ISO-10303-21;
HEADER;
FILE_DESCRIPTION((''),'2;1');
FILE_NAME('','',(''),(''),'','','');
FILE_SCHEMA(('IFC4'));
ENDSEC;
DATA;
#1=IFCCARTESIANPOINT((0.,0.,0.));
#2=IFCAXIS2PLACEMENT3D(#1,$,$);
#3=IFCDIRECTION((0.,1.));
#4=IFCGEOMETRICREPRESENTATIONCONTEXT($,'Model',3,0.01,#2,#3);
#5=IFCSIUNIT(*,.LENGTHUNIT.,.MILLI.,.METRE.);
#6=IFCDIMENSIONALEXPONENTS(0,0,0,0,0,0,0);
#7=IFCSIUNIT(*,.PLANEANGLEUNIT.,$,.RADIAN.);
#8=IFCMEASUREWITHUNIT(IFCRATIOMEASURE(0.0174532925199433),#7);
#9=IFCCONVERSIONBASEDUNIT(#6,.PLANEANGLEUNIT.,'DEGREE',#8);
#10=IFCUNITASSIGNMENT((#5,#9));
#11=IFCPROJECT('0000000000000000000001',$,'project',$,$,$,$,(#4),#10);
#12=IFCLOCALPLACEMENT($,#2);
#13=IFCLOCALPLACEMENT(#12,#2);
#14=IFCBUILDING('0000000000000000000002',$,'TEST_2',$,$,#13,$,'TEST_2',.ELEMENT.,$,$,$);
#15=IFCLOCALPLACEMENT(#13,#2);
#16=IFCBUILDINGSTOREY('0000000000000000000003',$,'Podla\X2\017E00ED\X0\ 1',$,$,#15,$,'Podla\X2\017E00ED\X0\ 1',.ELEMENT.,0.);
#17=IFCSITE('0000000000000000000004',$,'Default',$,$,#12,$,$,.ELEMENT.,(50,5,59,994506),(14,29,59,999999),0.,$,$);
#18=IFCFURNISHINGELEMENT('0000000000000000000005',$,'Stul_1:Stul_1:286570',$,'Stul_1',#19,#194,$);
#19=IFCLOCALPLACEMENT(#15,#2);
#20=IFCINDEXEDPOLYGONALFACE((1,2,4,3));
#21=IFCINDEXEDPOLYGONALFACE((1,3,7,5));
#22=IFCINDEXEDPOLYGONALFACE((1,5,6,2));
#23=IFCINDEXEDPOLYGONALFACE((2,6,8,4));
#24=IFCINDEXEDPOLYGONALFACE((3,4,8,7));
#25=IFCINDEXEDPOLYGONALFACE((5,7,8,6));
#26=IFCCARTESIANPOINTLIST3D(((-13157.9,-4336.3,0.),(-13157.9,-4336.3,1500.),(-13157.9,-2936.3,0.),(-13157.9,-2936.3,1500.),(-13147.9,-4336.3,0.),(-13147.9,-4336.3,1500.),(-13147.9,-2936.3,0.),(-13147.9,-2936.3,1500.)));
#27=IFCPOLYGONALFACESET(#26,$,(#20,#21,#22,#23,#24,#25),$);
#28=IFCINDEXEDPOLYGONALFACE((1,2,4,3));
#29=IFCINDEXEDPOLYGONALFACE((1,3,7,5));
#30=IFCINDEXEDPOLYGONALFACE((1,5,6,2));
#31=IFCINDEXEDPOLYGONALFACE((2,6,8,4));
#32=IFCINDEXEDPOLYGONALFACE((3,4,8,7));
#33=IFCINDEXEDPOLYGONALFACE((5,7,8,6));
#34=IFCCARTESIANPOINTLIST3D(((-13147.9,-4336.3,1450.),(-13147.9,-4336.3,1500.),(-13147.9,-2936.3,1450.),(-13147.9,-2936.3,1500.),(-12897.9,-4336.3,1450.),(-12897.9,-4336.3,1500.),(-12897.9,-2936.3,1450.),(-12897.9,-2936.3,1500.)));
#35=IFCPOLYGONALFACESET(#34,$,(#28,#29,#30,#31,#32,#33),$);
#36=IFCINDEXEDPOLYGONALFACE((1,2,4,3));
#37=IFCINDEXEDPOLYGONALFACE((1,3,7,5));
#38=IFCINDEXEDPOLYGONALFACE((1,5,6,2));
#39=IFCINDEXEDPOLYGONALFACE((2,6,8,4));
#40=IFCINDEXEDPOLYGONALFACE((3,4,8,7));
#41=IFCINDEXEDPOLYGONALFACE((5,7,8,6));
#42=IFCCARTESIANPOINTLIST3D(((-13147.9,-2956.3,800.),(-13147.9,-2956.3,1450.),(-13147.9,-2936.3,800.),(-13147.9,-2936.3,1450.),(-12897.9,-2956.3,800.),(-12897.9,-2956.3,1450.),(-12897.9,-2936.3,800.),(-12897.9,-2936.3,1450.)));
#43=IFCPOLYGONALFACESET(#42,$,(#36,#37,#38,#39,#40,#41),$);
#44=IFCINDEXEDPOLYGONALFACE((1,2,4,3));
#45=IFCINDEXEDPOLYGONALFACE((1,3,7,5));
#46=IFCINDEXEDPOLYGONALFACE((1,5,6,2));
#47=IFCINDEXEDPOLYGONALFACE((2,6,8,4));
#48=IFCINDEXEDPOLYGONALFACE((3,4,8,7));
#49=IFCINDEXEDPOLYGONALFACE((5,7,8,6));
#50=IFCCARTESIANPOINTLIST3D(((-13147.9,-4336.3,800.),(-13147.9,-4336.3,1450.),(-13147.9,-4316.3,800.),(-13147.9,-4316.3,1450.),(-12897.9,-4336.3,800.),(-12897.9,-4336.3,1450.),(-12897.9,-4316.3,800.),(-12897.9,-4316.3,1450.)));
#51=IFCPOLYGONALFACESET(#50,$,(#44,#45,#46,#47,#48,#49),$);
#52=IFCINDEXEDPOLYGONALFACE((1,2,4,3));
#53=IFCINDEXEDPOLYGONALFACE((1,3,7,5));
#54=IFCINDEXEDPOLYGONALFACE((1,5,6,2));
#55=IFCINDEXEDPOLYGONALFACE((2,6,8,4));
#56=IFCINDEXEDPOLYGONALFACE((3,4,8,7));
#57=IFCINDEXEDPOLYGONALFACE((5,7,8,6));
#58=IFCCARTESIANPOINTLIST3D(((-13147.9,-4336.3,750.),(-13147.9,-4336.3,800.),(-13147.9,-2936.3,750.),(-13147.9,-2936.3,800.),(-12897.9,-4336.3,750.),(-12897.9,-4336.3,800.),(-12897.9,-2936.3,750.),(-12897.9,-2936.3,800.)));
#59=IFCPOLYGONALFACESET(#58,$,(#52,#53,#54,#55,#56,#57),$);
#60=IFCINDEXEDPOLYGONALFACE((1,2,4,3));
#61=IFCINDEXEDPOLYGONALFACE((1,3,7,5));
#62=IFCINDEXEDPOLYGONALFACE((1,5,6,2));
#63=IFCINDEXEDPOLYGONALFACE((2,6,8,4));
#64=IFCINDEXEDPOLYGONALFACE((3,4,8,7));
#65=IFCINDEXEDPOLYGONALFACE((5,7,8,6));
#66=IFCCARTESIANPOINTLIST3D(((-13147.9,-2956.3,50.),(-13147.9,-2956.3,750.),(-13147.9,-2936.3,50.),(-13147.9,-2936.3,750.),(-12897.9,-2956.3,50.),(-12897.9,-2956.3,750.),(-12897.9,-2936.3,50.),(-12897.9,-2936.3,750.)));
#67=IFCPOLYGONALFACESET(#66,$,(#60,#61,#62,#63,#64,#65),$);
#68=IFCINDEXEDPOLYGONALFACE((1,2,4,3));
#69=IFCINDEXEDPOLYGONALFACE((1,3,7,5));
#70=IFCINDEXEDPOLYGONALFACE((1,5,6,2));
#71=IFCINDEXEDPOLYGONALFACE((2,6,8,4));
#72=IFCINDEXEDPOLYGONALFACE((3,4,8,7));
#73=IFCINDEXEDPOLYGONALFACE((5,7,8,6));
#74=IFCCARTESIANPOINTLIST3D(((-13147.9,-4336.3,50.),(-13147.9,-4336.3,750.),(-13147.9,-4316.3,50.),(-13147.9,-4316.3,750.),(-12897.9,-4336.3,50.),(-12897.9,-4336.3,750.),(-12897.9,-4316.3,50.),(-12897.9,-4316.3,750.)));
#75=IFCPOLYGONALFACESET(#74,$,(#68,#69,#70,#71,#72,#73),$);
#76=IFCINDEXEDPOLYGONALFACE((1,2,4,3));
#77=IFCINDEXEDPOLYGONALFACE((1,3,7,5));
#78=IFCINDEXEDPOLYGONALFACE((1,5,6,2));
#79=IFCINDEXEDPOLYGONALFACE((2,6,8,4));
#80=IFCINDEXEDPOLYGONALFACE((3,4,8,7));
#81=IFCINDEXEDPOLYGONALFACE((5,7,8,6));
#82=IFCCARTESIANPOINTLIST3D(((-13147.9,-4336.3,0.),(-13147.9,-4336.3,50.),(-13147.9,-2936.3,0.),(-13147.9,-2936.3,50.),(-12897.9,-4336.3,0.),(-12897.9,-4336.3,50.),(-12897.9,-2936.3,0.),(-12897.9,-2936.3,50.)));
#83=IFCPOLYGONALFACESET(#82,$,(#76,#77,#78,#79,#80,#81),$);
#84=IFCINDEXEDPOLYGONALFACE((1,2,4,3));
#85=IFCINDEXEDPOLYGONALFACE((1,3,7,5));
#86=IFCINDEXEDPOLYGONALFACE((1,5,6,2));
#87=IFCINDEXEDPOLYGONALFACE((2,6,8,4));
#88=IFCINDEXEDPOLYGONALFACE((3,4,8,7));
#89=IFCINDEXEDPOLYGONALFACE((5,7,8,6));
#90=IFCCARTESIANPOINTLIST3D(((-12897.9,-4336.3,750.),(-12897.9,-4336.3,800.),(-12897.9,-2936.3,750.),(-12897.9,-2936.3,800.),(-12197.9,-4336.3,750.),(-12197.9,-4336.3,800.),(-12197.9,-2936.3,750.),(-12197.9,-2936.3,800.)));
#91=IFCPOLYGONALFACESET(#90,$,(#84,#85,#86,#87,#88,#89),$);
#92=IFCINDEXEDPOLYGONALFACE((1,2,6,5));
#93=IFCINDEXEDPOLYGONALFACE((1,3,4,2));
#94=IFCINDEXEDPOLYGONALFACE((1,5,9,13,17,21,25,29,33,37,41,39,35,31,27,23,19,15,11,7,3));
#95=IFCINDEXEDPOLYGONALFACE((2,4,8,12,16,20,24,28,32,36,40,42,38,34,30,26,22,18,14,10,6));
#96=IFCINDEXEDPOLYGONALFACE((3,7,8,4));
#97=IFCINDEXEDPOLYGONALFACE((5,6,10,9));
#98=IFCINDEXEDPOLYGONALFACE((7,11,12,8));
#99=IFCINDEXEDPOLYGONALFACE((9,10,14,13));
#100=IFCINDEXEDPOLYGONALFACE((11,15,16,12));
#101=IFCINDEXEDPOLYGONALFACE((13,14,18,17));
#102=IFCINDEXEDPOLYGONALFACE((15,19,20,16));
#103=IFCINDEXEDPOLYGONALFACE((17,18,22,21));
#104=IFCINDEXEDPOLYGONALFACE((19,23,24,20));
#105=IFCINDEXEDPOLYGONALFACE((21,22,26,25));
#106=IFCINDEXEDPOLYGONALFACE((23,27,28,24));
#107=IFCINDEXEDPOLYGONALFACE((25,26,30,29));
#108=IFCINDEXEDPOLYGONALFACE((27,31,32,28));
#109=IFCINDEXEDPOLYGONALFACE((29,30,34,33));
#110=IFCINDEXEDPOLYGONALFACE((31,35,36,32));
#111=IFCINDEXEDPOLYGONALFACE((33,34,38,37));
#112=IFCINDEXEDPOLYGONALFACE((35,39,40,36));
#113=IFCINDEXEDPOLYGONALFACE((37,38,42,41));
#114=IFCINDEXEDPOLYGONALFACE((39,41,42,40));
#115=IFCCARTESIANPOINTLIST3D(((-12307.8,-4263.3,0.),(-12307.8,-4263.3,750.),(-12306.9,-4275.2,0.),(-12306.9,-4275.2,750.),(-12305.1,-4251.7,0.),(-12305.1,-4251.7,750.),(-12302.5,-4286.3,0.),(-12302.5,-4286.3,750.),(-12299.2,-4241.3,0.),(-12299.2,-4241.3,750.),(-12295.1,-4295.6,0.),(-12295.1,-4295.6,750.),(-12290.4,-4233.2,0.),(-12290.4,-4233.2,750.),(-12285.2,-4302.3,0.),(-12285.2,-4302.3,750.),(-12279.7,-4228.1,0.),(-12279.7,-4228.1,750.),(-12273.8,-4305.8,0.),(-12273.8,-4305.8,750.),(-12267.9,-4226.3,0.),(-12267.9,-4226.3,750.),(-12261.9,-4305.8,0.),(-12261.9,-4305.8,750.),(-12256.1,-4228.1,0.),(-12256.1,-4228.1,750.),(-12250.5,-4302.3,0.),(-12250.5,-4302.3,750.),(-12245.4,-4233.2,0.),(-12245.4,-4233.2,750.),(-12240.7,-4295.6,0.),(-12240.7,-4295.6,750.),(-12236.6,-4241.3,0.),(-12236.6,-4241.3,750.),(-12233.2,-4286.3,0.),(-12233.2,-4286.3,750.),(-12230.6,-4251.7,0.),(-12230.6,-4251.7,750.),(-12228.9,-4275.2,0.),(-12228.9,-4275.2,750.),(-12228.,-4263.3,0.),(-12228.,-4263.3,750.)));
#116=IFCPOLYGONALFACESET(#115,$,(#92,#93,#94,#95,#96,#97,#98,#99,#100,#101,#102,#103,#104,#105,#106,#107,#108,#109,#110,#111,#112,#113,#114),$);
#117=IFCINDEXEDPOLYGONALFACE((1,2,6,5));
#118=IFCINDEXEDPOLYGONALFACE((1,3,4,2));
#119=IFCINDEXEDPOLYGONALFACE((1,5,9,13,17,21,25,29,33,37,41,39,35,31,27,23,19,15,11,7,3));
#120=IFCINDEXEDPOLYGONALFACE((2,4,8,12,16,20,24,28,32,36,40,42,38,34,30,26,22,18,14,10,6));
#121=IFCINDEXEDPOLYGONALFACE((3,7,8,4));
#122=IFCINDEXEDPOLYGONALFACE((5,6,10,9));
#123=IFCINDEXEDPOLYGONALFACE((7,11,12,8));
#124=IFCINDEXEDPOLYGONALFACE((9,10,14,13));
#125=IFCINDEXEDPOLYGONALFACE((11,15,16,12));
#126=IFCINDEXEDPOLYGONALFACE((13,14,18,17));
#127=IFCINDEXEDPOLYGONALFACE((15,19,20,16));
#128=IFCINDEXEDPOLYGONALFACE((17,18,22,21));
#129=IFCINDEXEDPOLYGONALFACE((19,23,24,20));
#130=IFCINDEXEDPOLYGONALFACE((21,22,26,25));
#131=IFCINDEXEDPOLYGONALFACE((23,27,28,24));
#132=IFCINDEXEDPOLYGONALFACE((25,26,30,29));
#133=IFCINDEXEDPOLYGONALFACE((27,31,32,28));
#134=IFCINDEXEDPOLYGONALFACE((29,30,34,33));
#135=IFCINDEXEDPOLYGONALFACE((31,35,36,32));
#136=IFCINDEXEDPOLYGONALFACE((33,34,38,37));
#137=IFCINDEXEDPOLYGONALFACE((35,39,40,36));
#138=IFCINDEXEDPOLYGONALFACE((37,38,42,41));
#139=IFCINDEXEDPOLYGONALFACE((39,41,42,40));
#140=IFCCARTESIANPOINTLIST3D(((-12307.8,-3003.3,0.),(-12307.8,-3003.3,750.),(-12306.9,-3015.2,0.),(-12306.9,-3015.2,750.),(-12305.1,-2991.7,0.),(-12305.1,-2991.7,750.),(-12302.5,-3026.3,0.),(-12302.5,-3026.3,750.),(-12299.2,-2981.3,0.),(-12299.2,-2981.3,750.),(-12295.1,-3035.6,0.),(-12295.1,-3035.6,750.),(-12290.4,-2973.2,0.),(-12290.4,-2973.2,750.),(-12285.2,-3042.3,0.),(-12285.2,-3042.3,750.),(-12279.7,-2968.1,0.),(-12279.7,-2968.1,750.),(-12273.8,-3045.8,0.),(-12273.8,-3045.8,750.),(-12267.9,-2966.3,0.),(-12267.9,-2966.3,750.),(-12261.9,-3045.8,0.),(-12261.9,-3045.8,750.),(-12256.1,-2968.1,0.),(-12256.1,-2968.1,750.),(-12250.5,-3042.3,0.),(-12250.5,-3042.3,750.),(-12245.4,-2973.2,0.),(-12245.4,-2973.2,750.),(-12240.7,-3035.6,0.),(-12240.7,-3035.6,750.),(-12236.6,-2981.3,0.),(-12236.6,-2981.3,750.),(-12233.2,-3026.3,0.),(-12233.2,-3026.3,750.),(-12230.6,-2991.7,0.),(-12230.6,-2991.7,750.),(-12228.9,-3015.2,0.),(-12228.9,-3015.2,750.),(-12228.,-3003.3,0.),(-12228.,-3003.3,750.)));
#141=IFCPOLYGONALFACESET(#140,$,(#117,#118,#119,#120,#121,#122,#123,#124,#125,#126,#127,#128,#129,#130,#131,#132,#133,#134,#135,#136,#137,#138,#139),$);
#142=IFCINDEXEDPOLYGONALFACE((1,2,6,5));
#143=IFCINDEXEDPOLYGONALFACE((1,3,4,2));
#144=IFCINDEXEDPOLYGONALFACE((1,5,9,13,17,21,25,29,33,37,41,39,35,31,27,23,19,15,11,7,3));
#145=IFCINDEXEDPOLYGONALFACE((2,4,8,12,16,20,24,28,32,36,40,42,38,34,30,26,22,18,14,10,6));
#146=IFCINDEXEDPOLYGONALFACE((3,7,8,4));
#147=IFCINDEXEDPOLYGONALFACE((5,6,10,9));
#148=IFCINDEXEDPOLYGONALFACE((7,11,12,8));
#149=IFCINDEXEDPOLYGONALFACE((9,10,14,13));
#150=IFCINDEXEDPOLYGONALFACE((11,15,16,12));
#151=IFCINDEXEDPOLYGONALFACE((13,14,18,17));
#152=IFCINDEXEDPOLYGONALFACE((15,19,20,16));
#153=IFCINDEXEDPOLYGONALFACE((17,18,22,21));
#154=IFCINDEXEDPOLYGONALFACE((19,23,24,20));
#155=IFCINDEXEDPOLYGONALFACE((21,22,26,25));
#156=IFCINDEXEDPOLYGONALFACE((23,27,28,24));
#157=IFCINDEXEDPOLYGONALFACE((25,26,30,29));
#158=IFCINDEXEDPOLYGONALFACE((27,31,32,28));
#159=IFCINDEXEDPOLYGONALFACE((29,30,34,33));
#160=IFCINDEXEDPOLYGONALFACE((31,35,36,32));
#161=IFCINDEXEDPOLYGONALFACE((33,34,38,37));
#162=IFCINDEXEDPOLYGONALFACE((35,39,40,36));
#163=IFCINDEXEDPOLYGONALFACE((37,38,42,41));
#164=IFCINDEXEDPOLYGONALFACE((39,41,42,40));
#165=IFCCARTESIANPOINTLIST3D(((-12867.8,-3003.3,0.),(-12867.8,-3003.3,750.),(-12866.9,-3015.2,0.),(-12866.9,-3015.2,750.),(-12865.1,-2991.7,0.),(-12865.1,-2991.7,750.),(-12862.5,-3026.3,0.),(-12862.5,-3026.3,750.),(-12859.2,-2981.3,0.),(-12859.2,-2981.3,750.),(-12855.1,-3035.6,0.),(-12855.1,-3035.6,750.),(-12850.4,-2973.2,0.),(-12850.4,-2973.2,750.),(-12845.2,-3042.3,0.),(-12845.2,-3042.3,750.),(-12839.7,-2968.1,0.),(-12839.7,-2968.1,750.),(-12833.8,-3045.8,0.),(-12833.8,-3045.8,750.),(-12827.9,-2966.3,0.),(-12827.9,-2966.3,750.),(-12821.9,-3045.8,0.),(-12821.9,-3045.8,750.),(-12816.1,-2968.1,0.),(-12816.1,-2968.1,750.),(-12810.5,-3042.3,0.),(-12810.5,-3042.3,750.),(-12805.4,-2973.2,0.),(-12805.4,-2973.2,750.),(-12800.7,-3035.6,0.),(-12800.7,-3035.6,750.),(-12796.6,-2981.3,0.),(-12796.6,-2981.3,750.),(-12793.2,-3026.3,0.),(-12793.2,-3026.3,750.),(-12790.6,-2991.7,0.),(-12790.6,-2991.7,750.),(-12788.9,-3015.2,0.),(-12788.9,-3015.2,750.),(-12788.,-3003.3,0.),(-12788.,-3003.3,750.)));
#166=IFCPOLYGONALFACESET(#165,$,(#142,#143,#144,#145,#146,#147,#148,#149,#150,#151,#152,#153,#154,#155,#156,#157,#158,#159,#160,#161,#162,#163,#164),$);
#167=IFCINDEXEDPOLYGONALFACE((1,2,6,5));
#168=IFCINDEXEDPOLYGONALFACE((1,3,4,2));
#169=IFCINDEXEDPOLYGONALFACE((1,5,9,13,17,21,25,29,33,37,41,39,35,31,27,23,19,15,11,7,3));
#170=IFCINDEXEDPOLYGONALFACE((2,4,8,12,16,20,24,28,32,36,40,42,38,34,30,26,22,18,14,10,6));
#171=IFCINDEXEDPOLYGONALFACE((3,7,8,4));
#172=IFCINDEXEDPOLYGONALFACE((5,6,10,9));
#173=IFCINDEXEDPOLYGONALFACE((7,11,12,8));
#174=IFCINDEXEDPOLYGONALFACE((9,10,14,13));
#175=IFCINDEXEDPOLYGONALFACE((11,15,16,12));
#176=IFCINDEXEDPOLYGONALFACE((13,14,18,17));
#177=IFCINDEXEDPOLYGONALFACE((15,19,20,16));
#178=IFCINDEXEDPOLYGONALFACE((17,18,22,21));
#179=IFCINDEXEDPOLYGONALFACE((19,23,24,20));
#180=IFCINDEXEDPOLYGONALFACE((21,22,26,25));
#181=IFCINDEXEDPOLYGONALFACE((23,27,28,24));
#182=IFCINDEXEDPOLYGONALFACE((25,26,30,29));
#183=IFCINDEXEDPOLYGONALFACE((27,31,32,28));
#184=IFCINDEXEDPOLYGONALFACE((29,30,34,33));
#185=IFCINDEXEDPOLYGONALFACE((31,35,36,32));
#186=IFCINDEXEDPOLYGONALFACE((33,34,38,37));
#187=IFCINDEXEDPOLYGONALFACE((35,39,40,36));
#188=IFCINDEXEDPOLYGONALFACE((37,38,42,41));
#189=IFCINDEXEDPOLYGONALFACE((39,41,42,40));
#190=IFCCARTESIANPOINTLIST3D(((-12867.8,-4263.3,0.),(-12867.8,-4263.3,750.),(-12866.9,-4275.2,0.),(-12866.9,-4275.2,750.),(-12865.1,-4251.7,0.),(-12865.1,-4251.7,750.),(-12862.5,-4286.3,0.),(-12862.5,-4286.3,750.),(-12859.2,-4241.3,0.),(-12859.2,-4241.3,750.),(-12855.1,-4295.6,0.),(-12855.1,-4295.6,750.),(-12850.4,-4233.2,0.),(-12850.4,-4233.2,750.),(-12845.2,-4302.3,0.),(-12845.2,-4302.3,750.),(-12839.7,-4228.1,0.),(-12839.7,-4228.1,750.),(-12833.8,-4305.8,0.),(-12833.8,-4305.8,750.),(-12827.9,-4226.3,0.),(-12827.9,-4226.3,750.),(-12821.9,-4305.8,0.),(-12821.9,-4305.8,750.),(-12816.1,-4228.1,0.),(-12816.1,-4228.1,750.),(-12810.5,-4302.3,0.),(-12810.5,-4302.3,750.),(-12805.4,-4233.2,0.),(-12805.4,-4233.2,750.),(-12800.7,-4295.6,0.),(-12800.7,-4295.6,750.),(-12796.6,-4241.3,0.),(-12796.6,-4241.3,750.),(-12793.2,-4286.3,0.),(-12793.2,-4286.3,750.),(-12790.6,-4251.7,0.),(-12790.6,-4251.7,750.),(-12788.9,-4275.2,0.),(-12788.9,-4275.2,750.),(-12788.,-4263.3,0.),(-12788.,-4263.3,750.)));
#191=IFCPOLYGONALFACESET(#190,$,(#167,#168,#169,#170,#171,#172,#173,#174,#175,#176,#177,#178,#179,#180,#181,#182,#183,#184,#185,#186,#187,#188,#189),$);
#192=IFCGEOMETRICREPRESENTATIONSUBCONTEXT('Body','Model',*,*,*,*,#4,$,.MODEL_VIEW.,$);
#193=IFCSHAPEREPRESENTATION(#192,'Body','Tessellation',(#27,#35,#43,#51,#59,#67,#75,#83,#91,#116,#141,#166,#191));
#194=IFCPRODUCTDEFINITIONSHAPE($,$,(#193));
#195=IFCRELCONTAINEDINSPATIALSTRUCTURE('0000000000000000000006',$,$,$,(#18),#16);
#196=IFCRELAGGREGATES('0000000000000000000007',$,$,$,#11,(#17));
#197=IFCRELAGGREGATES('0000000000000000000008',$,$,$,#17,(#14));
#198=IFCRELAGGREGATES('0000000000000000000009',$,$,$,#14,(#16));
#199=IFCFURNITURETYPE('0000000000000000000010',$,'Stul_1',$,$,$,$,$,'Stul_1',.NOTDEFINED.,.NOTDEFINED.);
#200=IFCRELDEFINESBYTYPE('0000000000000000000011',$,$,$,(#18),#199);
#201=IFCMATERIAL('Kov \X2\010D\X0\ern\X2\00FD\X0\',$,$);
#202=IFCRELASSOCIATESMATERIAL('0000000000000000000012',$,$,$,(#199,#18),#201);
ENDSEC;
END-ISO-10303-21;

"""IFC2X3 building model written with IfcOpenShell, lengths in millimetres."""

from ifc_helpers import new_model, entity, si_unit, converted_unit, direction, frame, frame_2d, origin, origin_2d_with_axis, place, context, subcontext, project, spatial, rectangle, circle, extrude, source, transform, mapped, material, type_object, type_shapes, element, save


model = new_model("IFC2X3")

# Units and contexts
model_context = context("Model", 3, precision=0.01, world=origin(), true_north=direction((0.0, 1.0)))
body_context = subcontext(model_context, "Body", "Model", "MODEL_VIEW")
ifc_project = project(units=[si_unit("LENGTHUNIT", "METRE", prefix="MILLI"), converted_unit("PLANEANGLEUNIT", "DEGREE", entity("IfcRatioMeasure", 0.0174532925199433), si_unit("PLANEANGLEUNIT", "RADIAN"), dimensions=[0, 0, 0, 0, 0, 0, 0])], contexts=[model_context])

# Site, building, storey
site_placement = place(None, origin())
site = spatial("IfcSite", under=ifc_project, at=site_placement, Name="Default", CompositionType="ELEMENT", RefLatitude=(50, 5, 59, 994506), RefLongitude=(14, 29, 59, 999999), RefElevation=0.0)
building_placement = place(site_placement, origin())
building = spatial("IfcBuilding", under=site, at=building_placement, Name="TEST_2", LongName="TEST_2", CompositionType="ELEMENT")
storey_placement = place(building_placement, origin())
storey = spatial("IfcBuildingStorey", under=building, at=storey_placement, Name="Podlaží 1", LongName="Podlaží 1", CompositionType="ELEMENT", Elevation=0.0)

# Furnishing element
ifc_material_1 = material(Name="Kov černý")
furniture_type = type_object("IfcFurnitureType", Name="Stul_1", ElementType="Stul_1", material=ifc_material_1)
shared_shape_1 = source(origin(), body_context, "Body", "SweptSolid", [
    extrude(rectangle(XDim=1400.0, YDim=10.0, at=origin_2d_with_axis()), frame((0.0, 605.0, 0.0), z_axis=(0.0, 0.0, 1.0), x_axis=(-1.0, 0.0, 0.0)), (0.0, 0.0, 1.0), 1500.0),
    extrude(rectangle(XDim=1400.0, YDim=250.0, at=frame_2d((0.0, 0.0), x_axis=(1.0, 0.0))), frame((0.0, 475.0, 1450.0), z_axis=(0.0, 0.0, 1.0), x_axis=(-1.0, 0.0, 0.0)), (0.0, 0.0, 1.0), 50.0),
    extrude(rectangle(XDim=20.0, YDim=250.0, at=origin_2d_with_axis()), frame((690.0, 475.0, 800.0), z_axis=(0.0, 0.0, 1.0), x_axis=(-1.0, 0.0, 0.0)), (0.0, 0.0, 1.0), 650.0),
    extrude(rectangle(XDim=20.0, YDim=250.0, at=frame_2d((0.0, 0.0), x_axis=(1.0, 0.0))), frame((-690.0, 475.0, 800.0), z_axis=(0.0, 0.0, 1.0), x_axis=(-1.0, 0.0, 0.0)), (0.0, 0.0, 1.0), 650.0),
    extrude(rectangle(XDim=1400.0, YDim=250.0, at=origin_2d_with_axis()), frame((0.0, 475.0, 750.0), z_axis=(0.0, 0.0, 1.0), x_axis=(-1.0, 0.0, 0.0)), (0.0, 0.0, 1.0), 50.0),
    extrude(rectangle(XDim=20.0, YDim=250.0, at=origin_2d_with_axis()), frame((690.0, 475.0, 50.0), z_axis=(0.0, 0.0, 1.0), x_axis=(-1.0, 0.0, 0.0)), (0.0, 0.0, 1.0), 700.0),
    extrude(rectangle(XDim=20.0, YDim=250.0, at=frame_2d((0.0, 0.0), x_axis=(1.0, 0.0))), frame((-690.0, 475.0, 50.0), z_axis=(0.0, 0.0, 1.0), x_axis=(-1.0, 0.0, 0.0)), (0.0, 0.0, 1.0), 700.0),
    extrude(rectangle(XDim=1400.0, YDim=250.0, at=origin_2d_with_axis()), frame((0.0, 475.0, 0.0), z_axis=(0.0, 0.0, 1.0), x_axis=(-1.0, 0.0, 0.0)), (0.0, 0.0, 1.0), 50.0),
    extrude(rectangle(XDim=1400.0, YDim=700.0, at=origin_2d_with_axis()), frame((0.0, 0.0, 750.0), z_axis=(0.0, 0.0, 1.0), x_axis=(-1.0, 0.0, 0.0)), (0.0, 0.0, 1.0), 50.0),
    extrude(circle(Radius=40.0, at=frame_2d((0.0, 0.0), x_axis=(1.0, 0.0))), frame((-630.0, -280.0, 0.0)), (0.0, 0.0, 1.0), 750.0),
    extrude(circle(Radius=40.0, at=frame_2d((0.0, 0.0), x_axis=(1.0, 0.0))), frame((630.0, -280.0, 0.0)), (0.0, 0.0, 1.0), 750.0),
    extrude(circle(Radius=40.0, at=frame_2d((0.0, 0.0), x_axis=(1.0, 0.0))), frame((630.0, 280.0, 0.0)), (0.0, 0.0, 1.0), 750.0),
    extrude(circle(Radius=40.0, at=frame_2d((0.0, 0.0), x_axis=(1.0, 0.0))), frame((-630.0, 280.0, 0.0)), (0.0, 0.0, 1.0), 750.0),
])
type_shapes(furniture_type, [shared_shape_1])
for number, where, z_axis, x_axis, name in (
    (1, (-12547.9, -3636.3, 0.0), (0.0, 0.0, 1.0), (0.0, 1.0, 0.0), "Stul_1:Stul_1:286570"),
):
    element("IfcFurnishingElement", number, at=place(storey_placement, frame(where, z_axis=z_axis, x_axis=x_axis)), inside=storey, type_object=furniture_type, material=ifc_material_1, Name=name, ObjectType="Stul_1", context=body_context, shape_type="MappedRepresentation", body=[
        mapped(shared_shape_1, transform((0.0, 0.0, 0.0), scale=1.0)),
    ])

save(model, "model.ifc")
